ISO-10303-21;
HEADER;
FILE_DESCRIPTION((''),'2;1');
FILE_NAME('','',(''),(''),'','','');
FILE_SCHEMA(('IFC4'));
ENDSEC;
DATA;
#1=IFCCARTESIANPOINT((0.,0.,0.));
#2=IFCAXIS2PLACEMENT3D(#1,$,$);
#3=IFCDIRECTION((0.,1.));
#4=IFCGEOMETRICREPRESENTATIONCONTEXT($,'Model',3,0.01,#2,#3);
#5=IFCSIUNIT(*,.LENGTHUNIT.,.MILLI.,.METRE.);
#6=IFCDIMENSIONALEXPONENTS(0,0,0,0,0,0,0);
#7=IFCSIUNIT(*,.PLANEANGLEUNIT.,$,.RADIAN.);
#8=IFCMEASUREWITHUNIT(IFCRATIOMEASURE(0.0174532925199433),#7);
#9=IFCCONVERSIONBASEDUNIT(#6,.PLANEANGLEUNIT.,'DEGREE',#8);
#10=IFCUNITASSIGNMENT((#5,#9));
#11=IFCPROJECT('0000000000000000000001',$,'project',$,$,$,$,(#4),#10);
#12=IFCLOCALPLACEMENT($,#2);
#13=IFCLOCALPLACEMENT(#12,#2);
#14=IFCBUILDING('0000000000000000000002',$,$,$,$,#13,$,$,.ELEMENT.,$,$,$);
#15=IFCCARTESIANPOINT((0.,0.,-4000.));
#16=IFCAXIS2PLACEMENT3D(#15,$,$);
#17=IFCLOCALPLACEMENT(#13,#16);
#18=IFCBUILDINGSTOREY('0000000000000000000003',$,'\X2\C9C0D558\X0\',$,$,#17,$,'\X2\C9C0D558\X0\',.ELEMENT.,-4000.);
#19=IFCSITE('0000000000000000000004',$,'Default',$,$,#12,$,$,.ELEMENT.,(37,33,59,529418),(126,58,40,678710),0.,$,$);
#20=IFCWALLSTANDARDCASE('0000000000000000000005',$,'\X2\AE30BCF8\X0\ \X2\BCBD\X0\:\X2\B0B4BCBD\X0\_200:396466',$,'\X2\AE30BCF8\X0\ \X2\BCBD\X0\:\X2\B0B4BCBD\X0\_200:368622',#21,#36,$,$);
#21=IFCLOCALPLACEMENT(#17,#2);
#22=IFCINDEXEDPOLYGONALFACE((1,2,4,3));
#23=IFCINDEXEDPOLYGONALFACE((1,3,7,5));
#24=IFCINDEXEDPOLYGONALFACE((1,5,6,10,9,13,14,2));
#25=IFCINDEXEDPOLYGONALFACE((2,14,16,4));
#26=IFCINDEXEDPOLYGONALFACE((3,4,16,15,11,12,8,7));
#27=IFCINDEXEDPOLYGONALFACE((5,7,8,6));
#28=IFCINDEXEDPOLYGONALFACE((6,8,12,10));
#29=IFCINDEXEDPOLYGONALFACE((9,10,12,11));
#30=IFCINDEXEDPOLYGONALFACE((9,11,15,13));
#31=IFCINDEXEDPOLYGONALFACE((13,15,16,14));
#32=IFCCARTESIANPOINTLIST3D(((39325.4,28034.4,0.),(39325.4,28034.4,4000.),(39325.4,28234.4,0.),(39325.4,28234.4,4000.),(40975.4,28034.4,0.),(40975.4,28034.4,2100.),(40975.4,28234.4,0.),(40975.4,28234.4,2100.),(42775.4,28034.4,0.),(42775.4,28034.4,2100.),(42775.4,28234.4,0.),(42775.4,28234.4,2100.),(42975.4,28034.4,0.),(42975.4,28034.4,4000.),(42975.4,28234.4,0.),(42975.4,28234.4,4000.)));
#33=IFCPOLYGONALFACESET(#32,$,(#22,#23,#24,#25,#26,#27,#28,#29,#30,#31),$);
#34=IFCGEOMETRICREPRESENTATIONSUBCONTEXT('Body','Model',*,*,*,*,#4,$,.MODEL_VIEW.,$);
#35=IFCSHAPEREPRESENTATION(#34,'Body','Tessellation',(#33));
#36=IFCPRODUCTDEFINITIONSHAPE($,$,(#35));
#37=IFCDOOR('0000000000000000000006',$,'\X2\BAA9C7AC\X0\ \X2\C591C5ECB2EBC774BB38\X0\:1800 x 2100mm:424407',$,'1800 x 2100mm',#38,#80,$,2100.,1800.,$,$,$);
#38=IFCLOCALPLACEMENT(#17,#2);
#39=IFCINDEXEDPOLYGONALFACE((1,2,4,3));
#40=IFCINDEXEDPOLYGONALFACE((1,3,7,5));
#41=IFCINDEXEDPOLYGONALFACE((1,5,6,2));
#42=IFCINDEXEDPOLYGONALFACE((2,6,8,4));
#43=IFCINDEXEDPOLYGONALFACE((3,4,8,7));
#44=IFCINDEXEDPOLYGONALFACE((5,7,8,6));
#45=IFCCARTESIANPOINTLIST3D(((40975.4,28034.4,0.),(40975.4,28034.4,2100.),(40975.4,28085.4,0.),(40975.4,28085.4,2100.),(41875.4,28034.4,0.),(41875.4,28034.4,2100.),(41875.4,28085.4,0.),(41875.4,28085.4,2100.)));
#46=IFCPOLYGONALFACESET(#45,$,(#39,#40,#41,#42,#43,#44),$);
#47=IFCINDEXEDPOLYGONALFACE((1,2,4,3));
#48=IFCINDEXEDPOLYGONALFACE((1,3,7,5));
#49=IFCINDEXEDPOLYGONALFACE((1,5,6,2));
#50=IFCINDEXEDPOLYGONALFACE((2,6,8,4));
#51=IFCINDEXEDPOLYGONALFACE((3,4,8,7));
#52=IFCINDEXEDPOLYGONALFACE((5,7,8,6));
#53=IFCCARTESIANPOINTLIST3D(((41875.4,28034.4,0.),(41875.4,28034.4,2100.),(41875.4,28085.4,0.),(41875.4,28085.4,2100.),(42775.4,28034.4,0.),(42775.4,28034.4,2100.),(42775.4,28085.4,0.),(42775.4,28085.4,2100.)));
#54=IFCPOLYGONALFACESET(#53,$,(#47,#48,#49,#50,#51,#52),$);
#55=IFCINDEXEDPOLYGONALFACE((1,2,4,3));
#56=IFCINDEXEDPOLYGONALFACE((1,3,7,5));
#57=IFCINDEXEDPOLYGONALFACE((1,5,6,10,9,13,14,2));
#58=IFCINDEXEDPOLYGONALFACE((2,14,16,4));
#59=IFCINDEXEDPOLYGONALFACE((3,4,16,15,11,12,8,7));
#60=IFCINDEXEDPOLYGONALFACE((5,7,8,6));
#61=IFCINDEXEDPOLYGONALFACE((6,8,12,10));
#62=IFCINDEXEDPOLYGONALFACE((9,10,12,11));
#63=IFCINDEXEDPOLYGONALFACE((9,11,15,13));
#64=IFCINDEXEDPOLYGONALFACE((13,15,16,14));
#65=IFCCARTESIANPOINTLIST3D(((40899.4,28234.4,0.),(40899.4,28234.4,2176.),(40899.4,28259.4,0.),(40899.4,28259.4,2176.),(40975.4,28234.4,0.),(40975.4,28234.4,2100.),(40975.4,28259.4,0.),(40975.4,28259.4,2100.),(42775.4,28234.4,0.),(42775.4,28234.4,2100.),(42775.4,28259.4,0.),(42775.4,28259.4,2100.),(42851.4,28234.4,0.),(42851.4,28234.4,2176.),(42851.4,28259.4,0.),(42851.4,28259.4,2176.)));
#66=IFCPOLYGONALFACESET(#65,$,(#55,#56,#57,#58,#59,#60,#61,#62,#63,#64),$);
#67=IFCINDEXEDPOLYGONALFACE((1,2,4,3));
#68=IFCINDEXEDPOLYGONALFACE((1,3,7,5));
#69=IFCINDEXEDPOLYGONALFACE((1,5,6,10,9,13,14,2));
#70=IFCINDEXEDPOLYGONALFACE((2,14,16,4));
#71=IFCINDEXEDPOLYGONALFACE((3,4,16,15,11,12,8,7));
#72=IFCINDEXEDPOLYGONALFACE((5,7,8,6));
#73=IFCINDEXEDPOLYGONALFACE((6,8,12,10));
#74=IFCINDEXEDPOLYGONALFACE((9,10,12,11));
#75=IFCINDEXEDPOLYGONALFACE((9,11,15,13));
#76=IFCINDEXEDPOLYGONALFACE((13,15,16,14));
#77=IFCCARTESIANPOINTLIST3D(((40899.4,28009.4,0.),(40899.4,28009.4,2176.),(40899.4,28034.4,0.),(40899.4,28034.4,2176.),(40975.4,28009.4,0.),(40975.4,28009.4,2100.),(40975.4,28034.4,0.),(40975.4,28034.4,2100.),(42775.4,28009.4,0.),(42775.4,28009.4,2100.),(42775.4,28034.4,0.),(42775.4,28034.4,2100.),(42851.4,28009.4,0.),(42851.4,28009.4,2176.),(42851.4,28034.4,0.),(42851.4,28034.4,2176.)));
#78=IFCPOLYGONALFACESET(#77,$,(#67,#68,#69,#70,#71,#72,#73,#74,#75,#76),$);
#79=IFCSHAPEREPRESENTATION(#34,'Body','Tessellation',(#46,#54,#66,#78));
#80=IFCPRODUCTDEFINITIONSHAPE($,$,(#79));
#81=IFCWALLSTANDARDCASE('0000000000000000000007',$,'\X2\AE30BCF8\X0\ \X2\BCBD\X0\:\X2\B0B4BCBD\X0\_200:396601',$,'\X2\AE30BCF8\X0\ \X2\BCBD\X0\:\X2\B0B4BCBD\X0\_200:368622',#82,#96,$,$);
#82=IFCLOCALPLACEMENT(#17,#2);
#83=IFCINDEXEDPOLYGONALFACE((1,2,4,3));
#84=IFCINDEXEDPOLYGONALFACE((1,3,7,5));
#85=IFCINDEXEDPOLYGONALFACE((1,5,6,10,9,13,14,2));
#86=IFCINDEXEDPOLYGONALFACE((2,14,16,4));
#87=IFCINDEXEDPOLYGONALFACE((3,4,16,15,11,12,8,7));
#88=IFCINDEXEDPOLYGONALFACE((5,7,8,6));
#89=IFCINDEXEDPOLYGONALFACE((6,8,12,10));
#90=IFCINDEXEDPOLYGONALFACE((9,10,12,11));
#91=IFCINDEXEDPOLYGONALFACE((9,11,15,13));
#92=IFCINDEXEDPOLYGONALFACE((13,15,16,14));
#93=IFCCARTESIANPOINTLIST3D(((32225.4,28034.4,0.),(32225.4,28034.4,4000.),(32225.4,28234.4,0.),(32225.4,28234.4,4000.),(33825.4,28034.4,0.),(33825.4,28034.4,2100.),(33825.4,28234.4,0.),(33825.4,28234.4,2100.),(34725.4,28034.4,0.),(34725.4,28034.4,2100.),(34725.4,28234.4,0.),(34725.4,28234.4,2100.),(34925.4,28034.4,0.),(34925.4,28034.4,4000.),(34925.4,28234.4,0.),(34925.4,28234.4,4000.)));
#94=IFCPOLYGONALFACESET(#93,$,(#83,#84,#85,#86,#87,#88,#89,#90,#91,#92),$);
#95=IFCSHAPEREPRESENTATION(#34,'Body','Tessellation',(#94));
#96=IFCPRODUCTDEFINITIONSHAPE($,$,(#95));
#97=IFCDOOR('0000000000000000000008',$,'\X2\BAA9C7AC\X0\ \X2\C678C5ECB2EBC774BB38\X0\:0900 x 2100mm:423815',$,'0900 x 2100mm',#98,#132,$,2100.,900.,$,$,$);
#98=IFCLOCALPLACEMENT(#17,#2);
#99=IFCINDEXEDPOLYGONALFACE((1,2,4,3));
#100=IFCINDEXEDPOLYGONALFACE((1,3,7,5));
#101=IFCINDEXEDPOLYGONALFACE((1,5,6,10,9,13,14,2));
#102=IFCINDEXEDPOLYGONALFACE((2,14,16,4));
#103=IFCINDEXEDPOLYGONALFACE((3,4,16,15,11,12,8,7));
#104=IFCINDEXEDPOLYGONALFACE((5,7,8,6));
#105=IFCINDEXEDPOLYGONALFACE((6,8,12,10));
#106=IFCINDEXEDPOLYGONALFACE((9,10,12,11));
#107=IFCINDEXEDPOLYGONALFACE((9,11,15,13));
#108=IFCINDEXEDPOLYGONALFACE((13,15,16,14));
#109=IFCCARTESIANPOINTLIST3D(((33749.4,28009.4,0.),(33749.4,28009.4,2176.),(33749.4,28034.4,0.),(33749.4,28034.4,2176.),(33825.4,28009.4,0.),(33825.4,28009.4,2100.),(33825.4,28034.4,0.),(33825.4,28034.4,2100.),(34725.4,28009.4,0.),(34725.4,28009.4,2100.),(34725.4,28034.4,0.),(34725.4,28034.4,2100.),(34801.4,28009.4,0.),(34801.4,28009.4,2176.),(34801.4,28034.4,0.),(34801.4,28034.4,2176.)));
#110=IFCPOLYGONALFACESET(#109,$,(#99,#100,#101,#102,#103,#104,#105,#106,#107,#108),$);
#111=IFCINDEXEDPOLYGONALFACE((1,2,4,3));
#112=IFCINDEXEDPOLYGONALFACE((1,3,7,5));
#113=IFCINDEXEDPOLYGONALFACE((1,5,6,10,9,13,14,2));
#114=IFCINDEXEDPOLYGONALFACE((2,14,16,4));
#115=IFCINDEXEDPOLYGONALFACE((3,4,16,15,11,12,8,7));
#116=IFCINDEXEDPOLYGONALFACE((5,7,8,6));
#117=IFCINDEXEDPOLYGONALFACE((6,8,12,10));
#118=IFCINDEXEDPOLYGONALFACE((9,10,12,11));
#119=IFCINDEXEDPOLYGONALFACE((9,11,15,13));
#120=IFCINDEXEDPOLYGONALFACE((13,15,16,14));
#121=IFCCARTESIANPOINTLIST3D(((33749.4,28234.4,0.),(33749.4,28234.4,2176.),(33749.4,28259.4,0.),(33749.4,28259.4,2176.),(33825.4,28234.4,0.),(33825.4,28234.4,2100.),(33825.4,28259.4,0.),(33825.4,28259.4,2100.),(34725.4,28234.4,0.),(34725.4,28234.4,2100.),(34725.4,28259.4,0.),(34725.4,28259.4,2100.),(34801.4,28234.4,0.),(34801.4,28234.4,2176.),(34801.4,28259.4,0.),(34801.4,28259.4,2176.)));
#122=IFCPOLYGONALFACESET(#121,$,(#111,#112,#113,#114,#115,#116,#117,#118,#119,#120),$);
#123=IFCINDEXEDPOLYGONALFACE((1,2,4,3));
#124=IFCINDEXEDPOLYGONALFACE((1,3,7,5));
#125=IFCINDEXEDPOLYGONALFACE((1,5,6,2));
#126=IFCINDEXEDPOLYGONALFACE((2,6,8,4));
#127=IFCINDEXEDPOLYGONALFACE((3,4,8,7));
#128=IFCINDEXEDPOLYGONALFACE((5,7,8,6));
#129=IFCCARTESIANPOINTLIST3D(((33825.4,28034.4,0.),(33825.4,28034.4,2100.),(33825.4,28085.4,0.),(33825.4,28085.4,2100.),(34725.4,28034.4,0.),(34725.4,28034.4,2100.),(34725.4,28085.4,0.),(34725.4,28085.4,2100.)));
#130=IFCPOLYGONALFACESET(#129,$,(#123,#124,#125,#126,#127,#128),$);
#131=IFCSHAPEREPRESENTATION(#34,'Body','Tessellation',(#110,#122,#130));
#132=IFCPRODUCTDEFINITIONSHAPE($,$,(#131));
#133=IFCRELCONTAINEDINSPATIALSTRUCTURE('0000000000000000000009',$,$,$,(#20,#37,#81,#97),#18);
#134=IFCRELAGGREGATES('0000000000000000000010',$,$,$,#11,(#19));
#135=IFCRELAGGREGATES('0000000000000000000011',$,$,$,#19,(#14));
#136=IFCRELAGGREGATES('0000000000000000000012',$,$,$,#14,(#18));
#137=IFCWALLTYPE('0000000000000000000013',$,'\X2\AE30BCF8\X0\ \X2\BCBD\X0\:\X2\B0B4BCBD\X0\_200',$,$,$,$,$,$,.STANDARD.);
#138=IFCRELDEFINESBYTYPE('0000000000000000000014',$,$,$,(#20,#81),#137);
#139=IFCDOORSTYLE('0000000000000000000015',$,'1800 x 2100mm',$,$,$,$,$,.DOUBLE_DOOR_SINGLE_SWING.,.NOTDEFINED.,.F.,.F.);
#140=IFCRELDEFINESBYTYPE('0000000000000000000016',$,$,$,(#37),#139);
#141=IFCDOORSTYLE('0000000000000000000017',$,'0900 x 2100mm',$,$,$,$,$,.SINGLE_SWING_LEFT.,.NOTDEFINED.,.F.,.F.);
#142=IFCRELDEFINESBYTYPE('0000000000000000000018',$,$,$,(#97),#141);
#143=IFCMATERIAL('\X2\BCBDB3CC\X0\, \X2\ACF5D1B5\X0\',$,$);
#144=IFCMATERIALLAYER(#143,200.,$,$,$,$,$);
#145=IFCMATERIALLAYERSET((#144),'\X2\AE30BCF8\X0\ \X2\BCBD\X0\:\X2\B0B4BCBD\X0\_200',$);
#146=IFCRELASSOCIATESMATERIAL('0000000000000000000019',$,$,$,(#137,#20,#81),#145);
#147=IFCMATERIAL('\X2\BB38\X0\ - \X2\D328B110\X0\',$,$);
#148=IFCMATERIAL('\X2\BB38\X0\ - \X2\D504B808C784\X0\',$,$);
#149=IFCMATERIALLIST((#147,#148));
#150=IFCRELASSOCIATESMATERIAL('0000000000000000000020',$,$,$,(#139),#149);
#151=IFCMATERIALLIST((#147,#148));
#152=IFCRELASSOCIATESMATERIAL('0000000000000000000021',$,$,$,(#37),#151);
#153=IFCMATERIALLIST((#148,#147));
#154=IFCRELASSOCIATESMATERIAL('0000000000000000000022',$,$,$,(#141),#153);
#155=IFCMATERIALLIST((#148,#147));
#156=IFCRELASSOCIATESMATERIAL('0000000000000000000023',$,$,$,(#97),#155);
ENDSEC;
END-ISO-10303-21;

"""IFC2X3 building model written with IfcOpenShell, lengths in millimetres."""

from ifc_helpers import new_model, entity, si_unit, converted_unit, direction, frame, frame_2d, origin, place, context, subcontext, project, spatial, polyline, rectangle, outline, extrude, source, transform, mapped, material, material_list, layer, layer_set, layer_usage, type_object, type_shapes, element, fill, save


model = new_model("IFC2X3")

# Units and contexts
model_context = context("Model", 3, precision=0.01, world=origin(), true_north=direction((0.0, 1.0)))
body_context = subcontext(model_context, "Body", "Model", "MODEL_VIEW")
ifc_project = project(units=[si_unit("LENGTHUNIT", "METRE", prefix="MILLI"), converted_unit("PLANEANGLEUNIT", "DEGREE", entity("IfcRatioMeasure", 0.0174532925199433), si_unit("PLANEANGLEUNIT", "RADIAN"), dimensions=[0, 0, 0, 0, 0, 0, 0])], contexts=[model_context])

# Site, building, storey
site_placement = place(None, origin())
site = spatial("IfcSite", under=ifc_project, at=site_placement, Name="Default", CompositionType="ELEMENT", RefLatitude=(37, 33, 59, 529418), RefLongitude=(126, 58, 40, 678710), RefElevation=0.0)
building_placement = place(site_placement, origin())
building = spatial("IfcBuilding", under=site, at=building_placement, CompositionType="ELEMENT")
storey_placement = place(building_placement, frame((0.0, 0.0, -4000.0)))
storey = spatial("IfcBuildingStorey", under=building, at=storey_placement, Name="지하", LongName="지하", CompositionType="ELEMENT", Elevation=-4000.0)

# Shared definitions
ifc_material_1 = material(Name="벽돌, 공통")
ifc_layer_1 = layer(ifc_material_1, 200.0)
ifc_layer_set_1 = layer_set([ifc_layer_1], Name="기본 벽:내벽_200")
wall_type_1 = type_object("IfcWallType", Name="기본 벽:내벽_200", PredefinedType="STANDARD", material=ifc_layer_set_1)

# Walls, openings, doors
ifc_layer_usage_1 = layer_usage(ifc_layer_set_1, "AXIS2", "NEGATIVE", 100.0)
wall_1_placement = place(storey_placement, frame((39325.4, 28134.4, 0.0)))
wall_1 = element("IfcWallStandardCase", 1, at=wall_1_placement, inside=storey, type_object=wall_type_1, material=ifc_layer_usage_1, Name="기본 벽:내벽_200:396466", ObjectType="기본 벽:내벽_200:368622", context=body_context, shape_type="SweptSolid", body=[
    extrude(rectangle(XDim=3650.0, YDim=200.0, at=frame_2d((1825.0, 0.0), x_axis=(-1.0, 0.0))), origin(), (0.0, 0.0, 1.0), 4000.0),
])
opening_1_placement = place(wall_1_placement, frame((3450.0, 100.0, 0.0)))
opening_1 = element("IfcOpeningElement", 2, at=opening_1_placement, cuts=wall_1, ObjectType="Opening", context=body_context, shape_type="SweptSolid", body=[
    extrude(rectangle(XDim=2100.0, YDim=1800.0, at=frame_2d((1050.0, 900.0), x_axis=(1.0, 0.0))), frame((0.0, 0.0, 0.0), z_axis=(0.0, -1.0, 0.0), x_axis=(0.0, 0.0, 1.0)), (0.0, 0.0, 1.0), 200.0),
])
ifc_material_2 = material(Name="문 - 패널")
ifc_material_3 = material(Name="문 - 프레임")
ifc_material_list_1 = material_list([ifc_material_2, ifc_material_3])
ifc_material_list_2 = material_list([ifc_material_2, ifc_material_3])
door_style_1 = type_object("IfcDoorStyle", Name="1800 x 2100mm", ConstructionType="NOTDEFINED", OperationType="DOUBLE_DOOR_SINGLE_SWING", ParameterTakesPrecedence=False, Sizeable=False, material=ifc_material_list_2)
shared_shape_1 = source(origin(), body_context, "Body", "SweptSolid", [
    extrude(rectangle(XDim=51.0, YDim=900.0, at=frame_2d((0.0, 0.0), x_axis=(1.0, 0.0))), frame((1350.0, 174.5, 0.0), z_axis=(0.0, 0.0, 1.0), x_axis=(0.0, -1.0, 0.0)), (0.0, 0.0, 1.0), 2100.0),
    extrude(rectangle(XDim=51.0, YDim=900.0, at=frame_2d((0.0, 0.0), x_axis=(1.0, 0.0))), frame((450.0, 174.5, 0.0), z_axis=(0.0, 0.0, 1.0), x_axis=(0.0, -1.0, 0.0)), (0.0, 0.0, 1.0), 2100.0),
    extrude(outline(polyline([(-1031.0, 900.0), (1069.0, 900.0), (1069.0, 976.0), (-1107.0, 976.0), (-1107.0, -976.0), (1069.0, -976.0), (1069.0, -900.0), (-1031.0, -900.0), (-1031.0, 900.0)])), frame((900.0, -25.0, 1069.0), z_axis=(0.0, 1.0, 0.0), x_axis=(0.0, 0.0, -1.0)), (0.0, 0.0, 1.0), 25.0),
    extrude(outline(polyline([(-1031.0, 900.0), (1069.0, 900.0), (1069.0, 976.0), (-1107.0, 976.0), (-1107.0, -976.0), (1069.0, -976.0), (1069.0, -900.0), (-1031.0, -900.0), (-1031.0, 900.0)])), frame((900.0, 200.0, 1069.0), z_axis=(0.0, 1.0, 0.0), x_axis=(0.0, 0.0, -1.0)), (0.0, 0.0, 1.0), 25.0),
])
type_shapes(door_style_1, [shared_shape_1])
door_1_placement = place(opening_1_placement, frame((0.0, 0.0, 0.0), z_axis=(0.0, 0.0, 1.0), x_axis=(-1.0, 0.0, 0.0)))
door_1 = element("IfcDoor", 3, at=door_1_placement, inside=storey, type_object=door_style_1, material=ifc_material_list_1, Name="목재 양여닫이문:1800 x 2100mm:424407", ObjectType="1800 x 2100mm", OverallHeight=2100.0, OverallWidth=1800.0, context=body_context, shape_type="MappedRepresentation", body=[
    mapped(shared_shape_1, transform((0.0, 0.0, 0.0), scale=1.0)),
])
fill(opening_1, door_1)
ifc_layer_usage_2 = layer_usage(ifc_layer_set_1, "AXIS2", "NEGATIVE", 100.0)
wall_2_placement = place(storey_placement, frame((32225.4, 28134.4, 0.0)))
wall_2 = element("IfcWallStandardCase", 4, at=wall_2_placement, inside=storey, type_object=wall_type_1, material=ifc_layer_usage_2, Name="기본 벽:내벽_200:396601", ObjectType="기본 벽:내벽_200:368622", context=body_context, shape_type="SweptSolid", body=[
    extrude(rectangle(XDim=2700.0, YDim=200.0, at=frame_2d((1350.0, 0.0), x_axis=(-1.0, 0.0))), origin(), (0.0, 0.0, 1.0), 4000.0),
])
opening_2_placement = place(wall_2_placement, frame((2500.0, 100.0, 0.0)))
opening_2 = element("IfcOpeningElement", 5, at=opening_2_placement, cuts=wall_2, ObjectType="Opening", context=body_context, shape_type="SweptSolid", body=[
    extrude(rectangle(XDim=900.0, YDim=2100.0, at=frame_2d((1050.0, 450.0), x_axis=(0.0, -1.0))), frame((0.0, 0.0, 0.0), z_axis=(0.0, -1.0, 0.0), x_axis=(0.0, 0.0, 1.0)), (0.0, 0.0, 1.0), 200.0),
])
ifc_material_list_3 = material_list([ifc_material_3, ifc_material_2])
ifc_material_list_4 = material_list([ifc_material_3, ifc_material_2])
door_style_2 = type_object("IfcDoorStyle", Name="0900 x 2100mm", ConstructionType="NOTDEFINED", OperationType="SINGLE_SWING_LEFT", ParameterTakesPrecedence=False, Sizeable=False, material=ifc_material_list_4)
shared_shape_2 = source(origin(), body_context, "Body", "SweptSolid", [
    extrude(outline(polyline([(-526.0, -1107.0), (526.0, -1107.0), (526.0, 1069.0), (450.0, 1069.0), (450.0, -1031.0), (-450.0, -1031.0), (-450.0, 1069.0), (-526.0, 1069.0), (-526.0, -1107.0)])), frame((450.0, 225.0, 1069.0), z_axis=(0.0, -1.0, 0.0), x_axis=(-1.0, 0.0, 0.0)), (0.0, 0.0, 1.0), 25.0),
    extrude(outline(polyline([(-1107.0, -526.0), (1069.0, -526.0), (1069.0, -450.0), (-1031.0, -450.0), (-1031.0, 450.0), (1069.0, 450.0), (1069.0, 526.0), (-1107.0, 526.0), (-1107.0, -526.0)])), frame((450.0, 0.0, 1069.0), z_axis=(0.0, -1.0, 0.0), x_axis=(0.0, 0.0, -1.0)), (0.0, 0.0, 1.0), 25.0),
    extrude(rectangle(XDim=900.0, YDim=51.0, at=frame_2d((0.0, 0.0), x_axis=(1.0, 0.0))), frame((450.0, 174.5, 0.0)), (0.0, 0.0, 1.0), 2100.0),
])
type_shapes(door_style_2, [shared_shape_2])
door_2_placement = place(opening_2_placement, frame((0.0, 0.0, 0.0), z_axis=(0.0, 0.0, 1.0), x_axis=(-1.0, 0.0, 0.0)))
door_2 = element("IfcDoor", 6, at=door_2_placement, inside=storey, type_object=door_style_2, material=ifc_material_list_3, Name="목재 외여닫이문:0900 x 2100mm:423815", ObjectType="0900 x 2100mm", OverallHeight=2100.0, OverallWidth=900.0, context=body_context, shape_type="MappedRepresentation", body=[
    mapped(shared_shape_2, transform((0.0, 0.0, 0.0), scale=1.0)),
])
fill(opening_2, door_2)

save(model, "model.ifc")
